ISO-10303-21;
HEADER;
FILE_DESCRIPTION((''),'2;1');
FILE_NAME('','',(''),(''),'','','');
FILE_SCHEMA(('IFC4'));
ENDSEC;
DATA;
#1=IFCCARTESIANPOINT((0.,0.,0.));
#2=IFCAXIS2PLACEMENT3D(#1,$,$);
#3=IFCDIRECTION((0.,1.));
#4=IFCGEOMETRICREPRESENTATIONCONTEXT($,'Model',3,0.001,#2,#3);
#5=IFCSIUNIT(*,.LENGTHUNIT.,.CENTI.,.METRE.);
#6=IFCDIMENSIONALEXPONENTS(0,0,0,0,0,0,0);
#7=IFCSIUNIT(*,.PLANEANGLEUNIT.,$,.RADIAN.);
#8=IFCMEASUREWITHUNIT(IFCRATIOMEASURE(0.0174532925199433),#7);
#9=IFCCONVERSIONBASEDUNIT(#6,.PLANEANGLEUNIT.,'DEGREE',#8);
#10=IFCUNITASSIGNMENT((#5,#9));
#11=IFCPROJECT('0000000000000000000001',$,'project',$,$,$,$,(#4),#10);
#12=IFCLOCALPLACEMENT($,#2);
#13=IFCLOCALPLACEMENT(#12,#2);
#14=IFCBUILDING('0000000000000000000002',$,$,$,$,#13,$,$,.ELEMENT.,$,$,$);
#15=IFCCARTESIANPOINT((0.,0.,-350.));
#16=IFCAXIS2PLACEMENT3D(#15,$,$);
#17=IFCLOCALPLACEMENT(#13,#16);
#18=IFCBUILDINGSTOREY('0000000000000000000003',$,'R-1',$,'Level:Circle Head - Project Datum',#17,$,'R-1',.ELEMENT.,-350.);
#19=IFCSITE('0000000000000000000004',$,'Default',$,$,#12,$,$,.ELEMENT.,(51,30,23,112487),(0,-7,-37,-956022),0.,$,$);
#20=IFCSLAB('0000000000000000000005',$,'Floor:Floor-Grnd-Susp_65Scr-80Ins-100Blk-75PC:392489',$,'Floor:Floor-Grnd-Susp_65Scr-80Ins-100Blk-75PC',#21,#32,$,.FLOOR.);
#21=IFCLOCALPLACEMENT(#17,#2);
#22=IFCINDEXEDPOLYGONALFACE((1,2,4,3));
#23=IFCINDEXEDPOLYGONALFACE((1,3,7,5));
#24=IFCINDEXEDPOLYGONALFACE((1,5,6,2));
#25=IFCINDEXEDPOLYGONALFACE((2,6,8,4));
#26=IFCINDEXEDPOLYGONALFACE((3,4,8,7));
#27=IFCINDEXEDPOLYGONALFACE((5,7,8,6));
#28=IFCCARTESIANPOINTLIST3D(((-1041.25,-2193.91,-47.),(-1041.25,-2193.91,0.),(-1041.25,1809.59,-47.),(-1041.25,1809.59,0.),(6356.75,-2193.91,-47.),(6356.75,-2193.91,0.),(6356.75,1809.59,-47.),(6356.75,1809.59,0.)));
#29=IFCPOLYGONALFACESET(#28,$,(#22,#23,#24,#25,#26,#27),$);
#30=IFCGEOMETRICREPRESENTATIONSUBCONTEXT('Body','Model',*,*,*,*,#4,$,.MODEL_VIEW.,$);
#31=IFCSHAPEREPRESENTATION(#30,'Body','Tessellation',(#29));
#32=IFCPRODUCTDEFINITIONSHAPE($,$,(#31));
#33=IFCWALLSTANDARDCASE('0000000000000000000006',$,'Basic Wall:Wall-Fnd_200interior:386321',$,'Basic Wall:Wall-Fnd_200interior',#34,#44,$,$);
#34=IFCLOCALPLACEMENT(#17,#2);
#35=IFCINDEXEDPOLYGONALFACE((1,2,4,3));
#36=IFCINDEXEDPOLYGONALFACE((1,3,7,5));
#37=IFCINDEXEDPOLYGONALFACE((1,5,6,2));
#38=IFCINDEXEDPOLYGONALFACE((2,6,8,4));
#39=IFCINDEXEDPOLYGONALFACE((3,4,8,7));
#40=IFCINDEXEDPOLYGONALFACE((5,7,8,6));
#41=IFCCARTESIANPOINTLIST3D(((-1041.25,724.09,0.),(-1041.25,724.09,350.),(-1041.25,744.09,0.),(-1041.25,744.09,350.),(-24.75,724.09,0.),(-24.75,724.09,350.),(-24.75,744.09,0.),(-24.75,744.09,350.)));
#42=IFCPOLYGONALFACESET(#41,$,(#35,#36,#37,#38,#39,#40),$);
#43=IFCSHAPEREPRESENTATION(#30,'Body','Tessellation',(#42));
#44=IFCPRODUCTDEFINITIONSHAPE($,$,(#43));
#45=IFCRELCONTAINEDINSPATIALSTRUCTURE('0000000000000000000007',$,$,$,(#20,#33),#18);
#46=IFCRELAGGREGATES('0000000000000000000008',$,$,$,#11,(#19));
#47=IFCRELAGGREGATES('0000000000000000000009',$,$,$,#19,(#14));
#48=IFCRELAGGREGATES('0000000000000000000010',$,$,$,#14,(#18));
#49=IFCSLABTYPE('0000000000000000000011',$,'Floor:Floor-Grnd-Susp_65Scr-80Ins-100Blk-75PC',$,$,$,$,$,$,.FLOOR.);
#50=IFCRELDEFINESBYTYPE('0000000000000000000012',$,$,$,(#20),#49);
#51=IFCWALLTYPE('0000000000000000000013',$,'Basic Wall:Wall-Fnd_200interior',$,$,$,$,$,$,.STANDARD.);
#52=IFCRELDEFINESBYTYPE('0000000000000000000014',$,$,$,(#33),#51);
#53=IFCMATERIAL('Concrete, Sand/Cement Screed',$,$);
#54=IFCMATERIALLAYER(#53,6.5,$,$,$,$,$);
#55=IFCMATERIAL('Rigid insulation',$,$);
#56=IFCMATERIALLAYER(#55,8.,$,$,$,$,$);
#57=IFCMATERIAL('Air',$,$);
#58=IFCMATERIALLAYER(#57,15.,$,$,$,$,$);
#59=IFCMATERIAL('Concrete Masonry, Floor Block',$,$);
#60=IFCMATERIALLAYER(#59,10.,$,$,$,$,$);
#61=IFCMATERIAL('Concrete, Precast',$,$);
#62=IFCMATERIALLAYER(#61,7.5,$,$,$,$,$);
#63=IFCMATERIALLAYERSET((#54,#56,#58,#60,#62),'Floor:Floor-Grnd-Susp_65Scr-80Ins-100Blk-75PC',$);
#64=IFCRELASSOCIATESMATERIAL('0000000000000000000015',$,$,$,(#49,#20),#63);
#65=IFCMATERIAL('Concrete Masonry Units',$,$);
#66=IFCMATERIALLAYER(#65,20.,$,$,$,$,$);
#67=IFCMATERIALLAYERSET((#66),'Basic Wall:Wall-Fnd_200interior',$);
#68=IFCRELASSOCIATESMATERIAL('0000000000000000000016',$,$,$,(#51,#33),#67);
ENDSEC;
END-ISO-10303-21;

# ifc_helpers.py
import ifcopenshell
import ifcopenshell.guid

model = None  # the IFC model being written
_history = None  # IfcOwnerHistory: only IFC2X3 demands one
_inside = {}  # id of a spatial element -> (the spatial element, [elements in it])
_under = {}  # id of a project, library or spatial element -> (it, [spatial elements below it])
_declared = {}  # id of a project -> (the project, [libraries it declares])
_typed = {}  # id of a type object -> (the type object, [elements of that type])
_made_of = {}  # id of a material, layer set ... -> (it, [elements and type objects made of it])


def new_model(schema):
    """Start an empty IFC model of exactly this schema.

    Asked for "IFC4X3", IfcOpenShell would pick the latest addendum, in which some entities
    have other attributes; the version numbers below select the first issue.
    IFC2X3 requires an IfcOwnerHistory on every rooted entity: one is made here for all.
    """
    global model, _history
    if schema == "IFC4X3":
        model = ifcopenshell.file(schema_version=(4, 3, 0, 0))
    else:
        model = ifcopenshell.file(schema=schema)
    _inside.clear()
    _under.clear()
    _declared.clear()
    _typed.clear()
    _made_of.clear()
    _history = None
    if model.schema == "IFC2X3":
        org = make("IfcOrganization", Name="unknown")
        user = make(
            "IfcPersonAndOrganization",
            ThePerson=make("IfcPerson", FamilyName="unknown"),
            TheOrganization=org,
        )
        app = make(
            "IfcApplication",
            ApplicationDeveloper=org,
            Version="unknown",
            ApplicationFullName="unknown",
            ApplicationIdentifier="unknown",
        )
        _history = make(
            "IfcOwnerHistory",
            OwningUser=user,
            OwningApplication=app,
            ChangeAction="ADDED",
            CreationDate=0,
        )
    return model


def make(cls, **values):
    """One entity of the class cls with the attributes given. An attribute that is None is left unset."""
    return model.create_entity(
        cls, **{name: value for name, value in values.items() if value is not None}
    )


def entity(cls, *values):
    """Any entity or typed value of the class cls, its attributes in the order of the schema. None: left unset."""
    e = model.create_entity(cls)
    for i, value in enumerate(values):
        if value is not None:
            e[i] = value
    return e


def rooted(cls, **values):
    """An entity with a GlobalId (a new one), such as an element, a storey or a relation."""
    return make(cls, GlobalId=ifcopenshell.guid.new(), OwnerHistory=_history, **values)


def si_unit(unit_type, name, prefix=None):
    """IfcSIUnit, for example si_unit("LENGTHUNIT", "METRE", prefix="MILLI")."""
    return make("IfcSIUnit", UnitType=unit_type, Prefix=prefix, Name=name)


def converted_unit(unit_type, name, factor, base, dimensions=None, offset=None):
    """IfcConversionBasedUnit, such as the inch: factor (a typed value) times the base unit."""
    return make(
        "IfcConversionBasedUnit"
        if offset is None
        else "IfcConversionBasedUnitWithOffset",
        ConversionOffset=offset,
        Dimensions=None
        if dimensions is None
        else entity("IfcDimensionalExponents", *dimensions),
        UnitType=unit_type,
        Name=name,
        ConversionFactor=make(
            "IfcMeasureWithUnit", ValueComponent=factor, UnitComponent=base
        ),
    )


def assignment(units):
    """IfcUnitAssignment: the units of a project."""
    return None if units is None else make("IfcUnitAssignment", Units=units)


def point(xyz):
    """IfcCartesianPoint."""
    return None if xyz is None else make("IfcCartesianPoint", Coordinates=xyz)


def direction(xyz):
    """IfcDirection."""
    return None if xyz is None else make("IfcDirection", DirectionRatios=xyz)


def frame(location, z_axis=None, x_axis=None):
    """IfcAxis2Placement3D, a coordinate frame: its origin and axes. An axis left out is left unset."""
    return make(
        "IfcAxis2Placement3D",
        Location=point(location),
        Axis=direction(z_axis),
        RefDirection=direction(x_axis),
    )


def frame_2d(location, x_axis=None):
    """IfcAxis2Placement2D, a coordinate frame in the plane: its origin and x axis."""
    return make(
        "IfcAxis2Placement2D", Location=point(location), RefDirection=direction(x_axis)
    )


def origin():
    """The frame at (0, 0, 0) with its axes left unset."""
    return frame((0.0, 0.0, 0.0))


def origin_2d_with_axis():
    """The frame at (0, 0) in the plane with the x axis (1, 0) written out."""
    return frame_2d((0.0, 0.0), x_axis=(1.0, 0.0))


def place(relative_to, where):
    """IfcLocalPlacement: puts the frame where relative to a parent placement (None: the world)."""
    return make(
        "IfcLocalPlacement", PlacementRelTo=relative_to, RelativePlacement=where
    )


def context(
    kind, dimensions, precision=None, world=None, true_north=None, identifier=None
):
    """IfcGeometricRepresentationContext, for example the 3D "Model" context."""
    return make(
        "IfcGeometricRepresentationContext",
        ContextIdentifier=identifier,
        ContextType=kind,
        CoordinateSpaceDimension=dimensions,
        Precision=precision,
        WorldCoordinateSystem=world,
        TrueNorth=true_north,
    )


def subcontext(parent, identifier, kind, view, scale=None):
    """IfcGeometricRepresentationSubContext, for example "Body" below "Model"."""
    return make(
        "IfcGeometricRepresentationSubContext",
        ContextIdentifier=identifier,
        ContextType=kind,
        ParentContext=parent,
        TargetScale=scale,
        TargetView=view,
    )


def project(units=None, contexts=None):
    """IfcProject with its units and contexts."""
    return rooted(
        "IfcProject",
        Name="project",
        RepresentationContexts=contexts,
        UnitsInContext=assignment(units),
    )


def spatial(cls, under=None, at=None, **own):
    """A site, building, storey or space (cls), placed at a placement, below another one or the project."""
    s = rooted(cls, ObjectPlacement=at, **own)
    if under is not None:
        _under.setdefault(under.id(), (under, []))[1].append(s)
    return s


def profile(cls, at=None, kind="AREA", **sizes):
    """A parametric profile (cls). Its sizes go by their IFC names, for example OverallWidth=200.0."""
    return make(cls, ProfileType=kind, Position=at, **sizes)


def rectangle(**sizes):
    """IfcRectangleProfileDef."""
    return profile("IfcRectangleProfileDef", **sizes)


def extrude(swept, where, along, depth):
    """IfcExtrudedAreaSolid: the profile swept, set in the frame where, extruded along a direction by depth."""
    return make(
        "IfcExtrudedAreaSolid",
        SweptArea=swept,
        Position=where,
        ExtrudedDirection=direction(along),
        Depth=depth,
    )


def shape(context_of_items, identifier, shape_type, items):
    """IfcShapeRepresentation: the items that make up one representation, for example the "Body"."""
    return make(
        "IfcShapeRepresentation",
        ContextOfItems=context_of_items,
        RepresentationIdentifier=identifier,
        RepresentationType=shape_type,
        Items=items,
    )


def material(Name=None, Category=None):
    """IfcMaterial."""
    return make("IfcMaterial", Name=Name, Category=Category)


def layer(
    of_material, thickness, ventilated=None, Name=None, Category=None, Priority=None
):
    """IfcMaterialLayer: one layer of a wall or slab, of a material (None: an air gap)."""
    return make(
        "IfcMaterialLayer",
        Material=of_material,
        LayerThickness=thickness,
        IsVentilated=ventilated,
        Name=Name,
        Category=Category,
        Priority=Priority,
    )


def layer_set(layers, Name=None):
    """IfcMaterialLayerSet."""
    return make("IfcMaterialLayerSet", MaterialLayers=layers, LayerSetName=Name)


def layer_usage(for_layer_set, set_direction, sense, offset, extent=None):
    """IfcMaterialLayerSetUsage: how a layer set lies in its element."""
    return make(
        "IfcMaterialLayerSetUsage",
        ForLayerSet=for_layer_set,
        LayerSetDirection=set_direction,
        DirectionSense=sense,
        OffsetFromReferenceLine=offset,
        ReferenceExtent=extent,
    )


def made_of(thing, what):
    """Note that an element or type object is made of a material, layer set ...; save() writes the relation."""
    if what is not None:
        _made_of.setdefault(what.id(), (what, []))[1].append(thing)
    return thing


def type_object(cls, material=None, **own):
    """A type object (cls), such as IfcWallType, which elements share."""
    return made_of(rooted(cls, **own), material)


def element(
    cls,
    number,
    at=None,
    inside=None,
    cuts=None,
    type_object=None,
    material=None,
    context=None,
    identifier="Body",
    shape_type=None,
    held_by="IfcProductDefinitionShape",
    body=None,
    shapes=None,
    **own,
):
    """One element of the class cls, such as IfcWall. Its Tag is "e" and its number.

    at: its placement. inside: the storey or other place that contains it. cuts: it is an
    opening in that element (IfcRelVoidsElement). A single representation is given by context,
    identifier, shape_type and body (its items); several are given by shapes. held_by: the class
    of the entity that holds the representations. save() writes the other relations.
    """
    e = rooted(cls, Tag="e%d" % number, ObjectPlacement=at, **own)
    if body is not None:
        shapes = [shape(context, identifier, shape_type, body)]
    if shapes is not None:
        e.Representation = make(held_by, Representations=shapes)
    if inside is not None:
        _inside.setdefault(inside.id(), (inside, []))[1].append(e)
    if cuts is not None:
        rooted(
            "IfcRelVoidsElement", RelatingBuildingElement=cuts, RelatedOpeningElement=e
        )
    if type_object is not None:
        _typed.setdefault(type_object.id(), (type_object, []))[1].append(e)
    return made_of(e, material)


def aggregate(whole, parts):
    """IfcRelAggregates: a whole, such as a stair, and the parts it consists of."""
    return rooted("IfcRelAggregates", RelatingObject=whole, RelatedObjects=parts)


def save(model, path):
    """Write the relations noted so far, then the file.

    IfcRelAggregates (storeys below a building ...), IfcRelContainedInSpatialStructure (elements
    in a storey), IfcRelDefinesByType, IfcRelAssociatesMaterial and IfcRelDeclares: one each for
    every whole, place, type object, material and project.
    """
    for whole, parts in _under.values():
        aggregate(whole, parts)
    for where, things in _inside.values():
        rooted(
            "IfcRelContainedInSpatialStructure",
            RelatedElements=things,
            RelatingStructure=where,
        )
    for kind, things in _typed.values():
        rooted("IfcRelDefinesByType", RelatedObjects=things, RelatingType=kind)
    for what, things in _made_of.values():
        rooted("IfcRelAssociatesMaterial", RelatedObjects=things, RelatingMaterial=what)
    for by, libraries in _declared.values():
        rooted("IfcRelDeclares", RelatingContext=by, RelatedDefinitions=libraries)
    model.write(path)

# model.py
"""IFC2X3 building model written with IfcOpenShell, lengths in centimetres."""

from ifc_helpers import new_model, entity, si_unit, converted_unit, direction, frame, frame_2d, origin, origin_2d_with_axis, place, context, subcontext, project, spatial, rectangle, extrude, material, layer, layer_set, layer_usage, type_object, element, save


model = new_model("IFC2X3")

# Units and contexts
model_context = context("Model", 3, precision=0.001, world=origin(), true_north=direction((0.0, 1.0)))
body_context = subcontext(model_context, "Body", "Model", "MODEL_VIEW")
ifc_project = project(units=[si_unit("LENGTHUNIT", "METRE", prefix="CENTI"), converted_unit("PLANEANGLEUNIT", "DEGREE", entity("IfcRatioMeasure", 0.0174532925199433), si_unit("PLANEANGLEUNIT", "RADIAN"), dimensions=[0, 0, 0, 0, 0, 0, 0])], contexts=[model_context])

# Site, building, storey
site_placement = place(None, origin())
site = spatial("IfcSite", under=ifc_project, at=site_placement, Name="Default", CompositionType="ELEMENT", RefLatitude=(51, 30, 23, 112487), RefLongitude=(0, -7, -37, -956022), RefElevation=0.0)
building_placement = place(site_placement, origin())
building = spatial("IfcBuilding", under=site, at=building_placement, CompositionType="ELEMENT")
storey_placement = place(building_placement, frame((0.0, 0.0, -350.0)))
storey = spatial("IfcBuildingStorey", under=building, at=storey_placement, Name="R-1", ObjectType="Level:Circle Head - Project Datum", LongName="R-1", CompositionType="ELEMENT", Elevation=-350.0)

# Slab
ifc_material_1 = material(Name="Concrete, Sand/Cement Screed")
ifc_layer_1 = layer(ifc_material_1, 6.5)
ifc_material_2 = material(Name="Rigid insulation")
ifc_layer_2 = layer(ifc_material_2, 8.0)
ifc_material_3 = material(Name="Air")
ifc_layer_3 = layer(ifc_material_3, 15.0)
ifc_material_4 = material(Name="Concrete Masonry, Floor Block")
ifc_layer_4 = layer(ifc_material_4, 10.0)
ifc_material_5 = material(Name="Concrete, Precast")
ifc_layer_5 = layer(ifc_material_5, 7.5)
ifc_layer_set_1 = layer_set([ifc_layer_1, ifc_layer_2, ifc_layer_3, ifc_layer_4, ifc_layer_5], Name="Floor:Floor-Grnd-Susp_65Scr-80Ins-100Blk-75PC")
ifc_layer_usage_1 = layer_usage(ifc_layer_set_1, "AXIS3", "POSITIVE", 0.0)
slab_type = type_object("IfcSlabType", Name="Floor:Floor-Grnd-Susp_65Scr-80Ins-100Blk-75PC", PredefinedType="FLOOR", material=ifc_layer_set_1)
slab_placement = place(storey_placement, origin())
element("IfcSlab", 1, at=slab_placement, inside=storey, type_object=slab_type, material=ifc_layer_usage_1, Name="Floor:Floor-Grnd-Susp_65Scr-80Ins-100Blk-75PC:392489", ObjectType="Floor:Floor-Grnd-Susp_65Scr-80Ins-100Blk-75PC", PredefinedType="FLOOR", context=body_context, shape_type="SweptSolid", body=[
    extrude(rectangle(XDim=4003.5, YDim=7398.0, at=origin_2d_with_axis()), frame((2657.75, -192.16, 0.0), z_axis=(0.0, 0.0, -1.0), x_axis=(0.0, 1.0, 0.0)), (0.0, 0.0, 1.0), 47.0),
])

# Wall
ifc_material_6 = material(Name="Concrete Masonry Units")
ifc_layer_6 = layer(ifc_material_6, 20.0)
ifc_layer_set_2 = layer_set([ifc_layer_6], Name="Basic Wall:Wall-Fnd_200interior")
ifc_layer_usage_2 = layer_usage(ifc_layer_set_2, "AXIS2", "POSITIVE", -10.0)
wall_type = type_object("IfcWallType", Name="Basic Wall:Wall-Fnd_200interior", PredefinedType="STANDARD", material=ifc_layer_set_2)
wall_placement = place(storey_placement, frame((-24.75, 734.09, 0.0), z_axis=(0.0, 0.0, 1.0), x_axis=(-1.0, 0.0, 0.0)))
element("IfcWallStandardCase", 2, at=wall_placement, inside=storey, type_object=wall_type, material=ifc_layer_usage_2, Name="Basic Wall:Wall-Fnd_200interior:386321", ObjectType="Basic Wall:Wall-Fnd_200interior", context=body_context, shape_type="SweptSolid", body=[
    extrude(rectangle(XDim=1016.5, YDim=20.0, at=frame_2d((508.25, 0.0), x_axis=(-1.0, 0.0))), origin(), (0.0, 0.0, 1.0), 350.0),
])

save(model, "model.ifc")
